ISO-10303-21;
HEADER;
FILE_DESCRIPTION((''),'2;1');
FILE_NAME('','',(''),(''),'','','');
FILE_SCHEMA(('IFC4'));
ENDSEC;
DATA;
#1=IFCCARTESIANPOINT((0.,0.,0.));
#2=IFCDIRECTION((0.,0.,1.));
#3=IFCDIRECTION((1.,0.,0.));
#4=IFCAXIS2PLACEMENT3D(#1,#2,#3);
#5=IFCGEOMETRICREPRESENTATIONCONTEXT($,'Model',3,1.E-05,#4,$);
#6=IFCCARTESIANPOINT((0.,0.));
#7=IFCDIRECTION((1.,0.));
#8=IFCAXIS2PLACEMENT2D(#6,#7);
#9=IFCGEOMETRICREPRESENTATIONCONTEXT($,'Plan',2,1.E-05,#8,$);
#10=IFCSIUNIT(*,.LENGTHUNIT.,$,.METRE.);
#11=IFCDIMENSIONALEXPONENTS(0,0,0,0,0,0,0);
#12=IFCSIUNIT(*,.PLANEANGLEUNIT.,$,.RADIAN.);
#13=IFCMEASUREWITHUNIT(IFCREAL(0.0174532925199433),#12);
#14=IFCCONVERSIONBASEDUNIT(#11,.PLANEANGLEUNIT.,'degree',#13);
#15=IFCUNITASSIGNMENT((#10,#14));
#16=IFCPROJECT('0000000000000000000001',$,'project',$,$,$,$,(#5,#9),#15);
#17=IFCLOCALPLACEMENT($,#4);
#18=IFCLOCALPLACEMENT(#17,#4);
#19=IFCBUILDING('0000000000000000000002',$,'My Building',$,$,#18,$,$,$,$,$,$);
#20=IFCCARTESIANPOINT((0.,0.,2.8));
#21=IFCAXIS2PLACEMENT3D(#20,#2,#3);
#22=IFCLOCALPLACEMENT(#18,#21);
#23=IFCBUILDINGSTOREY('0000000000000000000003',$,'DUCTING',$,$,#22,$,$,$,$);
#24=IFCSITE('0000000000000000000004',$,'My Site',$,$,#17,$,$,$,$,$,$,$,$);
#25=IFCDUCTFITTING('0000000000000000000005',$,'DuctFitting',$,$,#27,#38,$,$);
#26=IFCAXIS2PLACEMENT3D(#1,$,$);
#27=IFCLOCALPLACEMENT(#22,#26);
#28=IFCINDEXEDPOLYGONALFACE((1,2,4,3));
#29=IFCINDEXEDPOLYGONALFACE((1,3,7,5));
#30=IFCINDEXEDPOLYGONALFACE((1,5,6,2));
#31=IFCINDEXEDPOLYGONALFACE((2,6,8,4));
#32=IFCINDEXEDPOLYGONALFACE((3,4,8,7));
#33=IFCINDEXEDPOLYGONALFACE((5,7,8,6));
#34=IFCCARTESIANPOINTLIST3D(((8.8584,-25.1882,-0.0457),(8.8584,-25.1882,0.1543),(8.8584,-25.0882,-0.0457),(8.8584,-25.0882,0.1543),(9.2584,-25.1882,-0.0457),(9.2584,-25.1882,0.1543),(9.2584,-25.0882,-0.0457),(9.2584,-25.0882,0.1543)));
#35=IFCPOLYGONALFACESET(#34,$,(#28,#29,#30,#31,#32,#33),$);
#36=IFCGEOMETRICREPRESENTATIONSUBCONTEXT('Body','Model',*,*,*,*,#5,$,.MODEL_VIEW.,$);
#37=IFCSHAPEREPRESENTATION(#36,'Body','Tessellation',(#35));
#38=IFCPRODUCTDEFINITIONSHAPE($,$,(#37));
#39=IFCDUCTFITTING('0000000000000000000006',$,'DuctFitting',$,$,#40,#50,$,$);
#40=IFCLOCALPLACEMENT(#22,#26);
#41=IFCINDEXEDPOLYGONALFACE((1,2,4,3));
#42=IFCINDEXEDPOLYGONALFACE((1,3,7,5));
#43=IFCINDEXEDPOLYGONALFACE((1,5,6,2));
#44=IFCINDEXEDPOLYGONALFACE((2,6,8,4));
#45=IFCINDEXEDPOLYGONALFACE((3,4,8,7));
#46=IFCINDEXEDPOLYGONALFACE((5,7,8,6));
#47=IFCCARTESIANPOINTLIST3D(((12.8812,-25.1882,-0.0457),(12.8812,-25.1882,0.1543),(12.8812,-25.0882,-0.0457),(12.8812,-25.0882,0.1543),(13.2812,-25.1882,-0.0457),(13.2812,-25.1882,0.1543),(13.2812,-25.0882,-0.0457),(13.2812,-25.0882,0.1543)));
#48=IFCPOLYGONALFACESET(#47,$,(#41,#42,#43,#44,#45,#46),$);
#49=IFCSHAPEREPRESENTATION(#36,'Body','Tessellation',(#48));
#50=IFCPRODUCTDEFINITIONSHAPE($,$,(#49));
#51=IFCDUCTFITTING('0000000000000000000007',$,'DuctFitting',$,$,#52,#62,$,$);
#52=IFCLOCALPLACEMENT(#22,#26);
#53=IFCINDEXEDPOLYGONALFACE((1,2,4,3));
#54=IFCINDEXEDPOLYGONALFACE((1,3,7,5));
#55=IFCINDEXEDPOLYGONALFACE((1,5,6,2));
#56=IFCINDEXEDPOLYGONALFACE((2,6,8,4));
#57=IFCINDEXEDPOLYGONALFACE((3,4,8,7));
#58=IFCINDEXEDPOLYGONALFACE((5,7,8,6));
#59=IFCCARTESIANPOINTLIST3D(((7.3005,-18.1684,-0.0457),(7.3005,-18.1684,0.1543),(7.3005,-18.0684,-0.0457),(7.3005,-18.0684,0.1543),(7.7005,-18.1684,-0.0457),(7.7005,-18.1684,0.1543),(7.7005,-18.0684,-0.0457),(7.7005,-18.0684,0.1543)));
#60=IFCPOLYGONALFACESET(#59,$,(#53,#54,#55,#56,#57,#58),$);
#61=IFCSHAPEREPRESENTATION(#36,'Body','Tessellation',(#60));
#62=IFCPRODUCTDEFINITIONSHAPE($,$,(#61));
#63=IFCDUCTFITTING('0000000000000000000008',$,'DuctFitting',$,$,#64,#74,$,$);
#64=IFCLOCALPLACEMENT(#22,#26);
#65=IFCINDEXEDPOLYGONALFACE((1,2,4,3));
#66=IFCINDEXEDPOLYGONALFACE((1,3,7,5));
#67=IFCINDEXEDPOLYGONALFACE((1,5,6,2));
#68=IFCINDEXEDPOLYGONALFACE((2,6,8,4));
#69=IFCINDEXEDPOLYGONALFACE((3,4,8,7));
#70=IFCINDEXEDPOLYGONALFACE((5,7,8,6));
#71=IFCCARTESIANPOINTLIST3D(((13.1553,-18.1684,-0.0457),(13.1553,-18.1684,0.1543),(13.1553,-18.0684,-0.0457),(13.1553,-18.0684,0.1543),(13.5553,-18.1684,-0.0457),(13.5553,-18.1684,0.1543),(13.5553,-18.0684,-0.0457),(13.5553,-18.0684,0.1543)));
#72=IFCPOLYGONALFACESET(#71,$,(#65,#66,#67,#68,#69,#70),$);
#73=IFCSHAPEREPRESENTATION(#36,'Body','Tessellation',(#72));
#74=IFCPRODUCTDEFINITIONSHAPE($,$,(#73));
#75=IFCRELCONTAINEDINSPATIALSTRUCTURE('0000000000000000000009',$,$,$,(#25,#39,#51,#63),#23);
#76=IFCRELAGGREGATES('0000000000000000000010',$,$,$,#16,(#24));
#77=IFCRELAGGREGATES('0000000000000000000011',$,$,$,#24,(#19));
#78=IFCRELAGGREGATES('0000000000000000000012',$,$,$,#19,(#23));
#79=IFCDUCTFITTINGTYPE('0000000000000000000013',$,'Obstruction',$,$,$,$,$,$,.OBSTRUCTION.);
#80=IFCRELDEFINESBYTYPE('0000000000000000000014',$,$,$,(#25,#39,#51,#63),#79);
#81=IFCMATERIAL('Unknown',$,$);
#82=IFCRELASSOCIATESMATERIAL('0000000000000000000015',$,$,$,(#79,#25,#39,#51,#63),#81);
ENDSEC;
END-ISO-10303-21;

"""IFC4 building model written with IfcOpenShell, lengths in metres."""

from ifc_helpers import new_model, entity, si_unit, converted_unit, frame, origin_with_axes, origin_2d_with_axis, place, context, subcontext, project, spatial, rectangle, extrude, material, material_profile, profile_set, profile_usage, type_object, element, save


model = new_model("IFC4")

# Units and contexts
model_context = context("Model", 3, precision=1e-05, world=origin_with_axes())
plan_context = context("Plan", 2, precision=1e-05, world=origin_2d_with_axis())
body_context = subcontext(model_context, "Body", "Model", "MODEL_VIEW")
ifc_project = project(units=[si_unit("LENGTHUNIT", "METRE"), converted_unit("PLANEANGLEUNIT", "degree", entity("IfcReal", 0.0174532925199433), si_unit("PLANEANGLEUNIT", "RADIAN"), dimensions=[0, 0, 0, 0, 0, 0, 0])], contexts=[model_context, plan_context])

# Site, building, storey
site_placement = place(None, origin_with_axes())
site = spatial("IfcSite", under=ifc_project, at=site_placement, Name="My Site")
building_placement = place(site_placement, origin_with_axes())
building = spatial("IfcBuilding", under=site, at=building_placement, Name="My Building")
storey_placement = place(building_placement, frame((0.0, 0.0, 2.8), z_axis=(0.0, 0.0, 1.0), x_axis=(1.0, 0.0, 0.0)))
storey = spatial("IfcBuildingStorey", under=building, at=storey_placement, Name="DUCTING")

# Shared definitions
ifc_material = material(Name="Unknown")

# Duct fittings
ifc_material_profile_1 = material_profile(ifc_material, rectangle(XDim=0.4, YDim=0.2))
ifc_profile_set_1 = profile_set([ifc_material_profile_1])
duct_fitting_type_1 = type_object("IfcDuctFittingType", Name="Obstruction", PredefinedType="OBSTRUCTION", material=ifc_profile_set_1)
ifc_profile_usage_1 = profile_usage(ifc_profile_set_1, cardinal=5)
duct_fitting_1_placement = place(storey_placement, frame((9.0584, -25.1882, 0.0543), z_axis=(0.0, 1.0, 0.0), x_axis=(-1.0, 0.0, 0.0)))
element("IfcDuctFitting", 1, at=duct_fitting_1_placement, inside=storey, type_object=duct_fitting_type_1, material=ifc_profile_usage_1, Name="DuctFitting", context=body_context, shape_type="SweptSolid", body=[
    extrude(rectangle(XDim=0.4, YDim=0.2), origin_with_axes(), (0.0, 0.0, 1.0), 0.1),
])
ifc_profile_usage_2 = profile_usage(ifc_profile_set_1, cardinal=5)
duct_fitting_2_placement = place(storey_placement, frame((13.0812, -25.1882, 0.0543), z_axis=(0.0, 1.0, 0.0), x_axis=(-1.0, 0.0, 0.0)))
element("IfcDuctFitting", 2, at=duct_fitting_2_placement, inside=storey, type_object=duct_fitting_type_1, material=ifc_profile_usage_2, Name="DuctFitting", context=body_context, shape_type="SweptSolid", body=[
    extrude(rectangle(XDim=0.4, YDim=0.2), origin_with_axes(), (0.0, 0.0, 1.0), 0.1),
])
ifc_profile_usage_3 = profile_usage(ifc_profile_set_1, cardinal=5)
duct_fitting_3_placement = place(storey_placement, frame((7.5005, -18.1684, 0.0543), z_axis=(0.0, 1.0, 0.0), x_axis=(-1.0, 0.0, 0.0)))
element("IfcDuctFitting", 3, at=duct_fitting_3_placement, inside=storey, type_object=duct_fitting_type_1, material=ifc_profile_usage_3, Name="DuctFitting", context=body_context, shape_type="SweptSolid", body=[
    extrude(rectangle(XDim=0.4, YDim=0.2), origin_with_axes(), (0.0, 0.0, 1.0), 0.1),
])
ifc_profile_usage_4 = profile_usage(ifc_profile_set_1, cardinal=5)
duct_fitting_4_placement = place(storey_placement, frame((13.3553, -18.1684, 0.0543), z_axis=(0.0, 1.0, 0.0), x_axis=(-1.0, 0.0, 0.0)))
element("IfcDuctFitting", 4, at=duct_fitting_4_placement, inside=storey, type_object=duct_fitting_type_1, material=ifc_profile_usage_4, Name="DuctFitting", context=body_context, shape_type="SweptSolid", body=[
    extrude(rectangle(XDim=0.4, YDim=0.2), origin_with_axes(), (0.0, 0.0, 1.0), 0.1),
])

save(model, "model.ifc")
